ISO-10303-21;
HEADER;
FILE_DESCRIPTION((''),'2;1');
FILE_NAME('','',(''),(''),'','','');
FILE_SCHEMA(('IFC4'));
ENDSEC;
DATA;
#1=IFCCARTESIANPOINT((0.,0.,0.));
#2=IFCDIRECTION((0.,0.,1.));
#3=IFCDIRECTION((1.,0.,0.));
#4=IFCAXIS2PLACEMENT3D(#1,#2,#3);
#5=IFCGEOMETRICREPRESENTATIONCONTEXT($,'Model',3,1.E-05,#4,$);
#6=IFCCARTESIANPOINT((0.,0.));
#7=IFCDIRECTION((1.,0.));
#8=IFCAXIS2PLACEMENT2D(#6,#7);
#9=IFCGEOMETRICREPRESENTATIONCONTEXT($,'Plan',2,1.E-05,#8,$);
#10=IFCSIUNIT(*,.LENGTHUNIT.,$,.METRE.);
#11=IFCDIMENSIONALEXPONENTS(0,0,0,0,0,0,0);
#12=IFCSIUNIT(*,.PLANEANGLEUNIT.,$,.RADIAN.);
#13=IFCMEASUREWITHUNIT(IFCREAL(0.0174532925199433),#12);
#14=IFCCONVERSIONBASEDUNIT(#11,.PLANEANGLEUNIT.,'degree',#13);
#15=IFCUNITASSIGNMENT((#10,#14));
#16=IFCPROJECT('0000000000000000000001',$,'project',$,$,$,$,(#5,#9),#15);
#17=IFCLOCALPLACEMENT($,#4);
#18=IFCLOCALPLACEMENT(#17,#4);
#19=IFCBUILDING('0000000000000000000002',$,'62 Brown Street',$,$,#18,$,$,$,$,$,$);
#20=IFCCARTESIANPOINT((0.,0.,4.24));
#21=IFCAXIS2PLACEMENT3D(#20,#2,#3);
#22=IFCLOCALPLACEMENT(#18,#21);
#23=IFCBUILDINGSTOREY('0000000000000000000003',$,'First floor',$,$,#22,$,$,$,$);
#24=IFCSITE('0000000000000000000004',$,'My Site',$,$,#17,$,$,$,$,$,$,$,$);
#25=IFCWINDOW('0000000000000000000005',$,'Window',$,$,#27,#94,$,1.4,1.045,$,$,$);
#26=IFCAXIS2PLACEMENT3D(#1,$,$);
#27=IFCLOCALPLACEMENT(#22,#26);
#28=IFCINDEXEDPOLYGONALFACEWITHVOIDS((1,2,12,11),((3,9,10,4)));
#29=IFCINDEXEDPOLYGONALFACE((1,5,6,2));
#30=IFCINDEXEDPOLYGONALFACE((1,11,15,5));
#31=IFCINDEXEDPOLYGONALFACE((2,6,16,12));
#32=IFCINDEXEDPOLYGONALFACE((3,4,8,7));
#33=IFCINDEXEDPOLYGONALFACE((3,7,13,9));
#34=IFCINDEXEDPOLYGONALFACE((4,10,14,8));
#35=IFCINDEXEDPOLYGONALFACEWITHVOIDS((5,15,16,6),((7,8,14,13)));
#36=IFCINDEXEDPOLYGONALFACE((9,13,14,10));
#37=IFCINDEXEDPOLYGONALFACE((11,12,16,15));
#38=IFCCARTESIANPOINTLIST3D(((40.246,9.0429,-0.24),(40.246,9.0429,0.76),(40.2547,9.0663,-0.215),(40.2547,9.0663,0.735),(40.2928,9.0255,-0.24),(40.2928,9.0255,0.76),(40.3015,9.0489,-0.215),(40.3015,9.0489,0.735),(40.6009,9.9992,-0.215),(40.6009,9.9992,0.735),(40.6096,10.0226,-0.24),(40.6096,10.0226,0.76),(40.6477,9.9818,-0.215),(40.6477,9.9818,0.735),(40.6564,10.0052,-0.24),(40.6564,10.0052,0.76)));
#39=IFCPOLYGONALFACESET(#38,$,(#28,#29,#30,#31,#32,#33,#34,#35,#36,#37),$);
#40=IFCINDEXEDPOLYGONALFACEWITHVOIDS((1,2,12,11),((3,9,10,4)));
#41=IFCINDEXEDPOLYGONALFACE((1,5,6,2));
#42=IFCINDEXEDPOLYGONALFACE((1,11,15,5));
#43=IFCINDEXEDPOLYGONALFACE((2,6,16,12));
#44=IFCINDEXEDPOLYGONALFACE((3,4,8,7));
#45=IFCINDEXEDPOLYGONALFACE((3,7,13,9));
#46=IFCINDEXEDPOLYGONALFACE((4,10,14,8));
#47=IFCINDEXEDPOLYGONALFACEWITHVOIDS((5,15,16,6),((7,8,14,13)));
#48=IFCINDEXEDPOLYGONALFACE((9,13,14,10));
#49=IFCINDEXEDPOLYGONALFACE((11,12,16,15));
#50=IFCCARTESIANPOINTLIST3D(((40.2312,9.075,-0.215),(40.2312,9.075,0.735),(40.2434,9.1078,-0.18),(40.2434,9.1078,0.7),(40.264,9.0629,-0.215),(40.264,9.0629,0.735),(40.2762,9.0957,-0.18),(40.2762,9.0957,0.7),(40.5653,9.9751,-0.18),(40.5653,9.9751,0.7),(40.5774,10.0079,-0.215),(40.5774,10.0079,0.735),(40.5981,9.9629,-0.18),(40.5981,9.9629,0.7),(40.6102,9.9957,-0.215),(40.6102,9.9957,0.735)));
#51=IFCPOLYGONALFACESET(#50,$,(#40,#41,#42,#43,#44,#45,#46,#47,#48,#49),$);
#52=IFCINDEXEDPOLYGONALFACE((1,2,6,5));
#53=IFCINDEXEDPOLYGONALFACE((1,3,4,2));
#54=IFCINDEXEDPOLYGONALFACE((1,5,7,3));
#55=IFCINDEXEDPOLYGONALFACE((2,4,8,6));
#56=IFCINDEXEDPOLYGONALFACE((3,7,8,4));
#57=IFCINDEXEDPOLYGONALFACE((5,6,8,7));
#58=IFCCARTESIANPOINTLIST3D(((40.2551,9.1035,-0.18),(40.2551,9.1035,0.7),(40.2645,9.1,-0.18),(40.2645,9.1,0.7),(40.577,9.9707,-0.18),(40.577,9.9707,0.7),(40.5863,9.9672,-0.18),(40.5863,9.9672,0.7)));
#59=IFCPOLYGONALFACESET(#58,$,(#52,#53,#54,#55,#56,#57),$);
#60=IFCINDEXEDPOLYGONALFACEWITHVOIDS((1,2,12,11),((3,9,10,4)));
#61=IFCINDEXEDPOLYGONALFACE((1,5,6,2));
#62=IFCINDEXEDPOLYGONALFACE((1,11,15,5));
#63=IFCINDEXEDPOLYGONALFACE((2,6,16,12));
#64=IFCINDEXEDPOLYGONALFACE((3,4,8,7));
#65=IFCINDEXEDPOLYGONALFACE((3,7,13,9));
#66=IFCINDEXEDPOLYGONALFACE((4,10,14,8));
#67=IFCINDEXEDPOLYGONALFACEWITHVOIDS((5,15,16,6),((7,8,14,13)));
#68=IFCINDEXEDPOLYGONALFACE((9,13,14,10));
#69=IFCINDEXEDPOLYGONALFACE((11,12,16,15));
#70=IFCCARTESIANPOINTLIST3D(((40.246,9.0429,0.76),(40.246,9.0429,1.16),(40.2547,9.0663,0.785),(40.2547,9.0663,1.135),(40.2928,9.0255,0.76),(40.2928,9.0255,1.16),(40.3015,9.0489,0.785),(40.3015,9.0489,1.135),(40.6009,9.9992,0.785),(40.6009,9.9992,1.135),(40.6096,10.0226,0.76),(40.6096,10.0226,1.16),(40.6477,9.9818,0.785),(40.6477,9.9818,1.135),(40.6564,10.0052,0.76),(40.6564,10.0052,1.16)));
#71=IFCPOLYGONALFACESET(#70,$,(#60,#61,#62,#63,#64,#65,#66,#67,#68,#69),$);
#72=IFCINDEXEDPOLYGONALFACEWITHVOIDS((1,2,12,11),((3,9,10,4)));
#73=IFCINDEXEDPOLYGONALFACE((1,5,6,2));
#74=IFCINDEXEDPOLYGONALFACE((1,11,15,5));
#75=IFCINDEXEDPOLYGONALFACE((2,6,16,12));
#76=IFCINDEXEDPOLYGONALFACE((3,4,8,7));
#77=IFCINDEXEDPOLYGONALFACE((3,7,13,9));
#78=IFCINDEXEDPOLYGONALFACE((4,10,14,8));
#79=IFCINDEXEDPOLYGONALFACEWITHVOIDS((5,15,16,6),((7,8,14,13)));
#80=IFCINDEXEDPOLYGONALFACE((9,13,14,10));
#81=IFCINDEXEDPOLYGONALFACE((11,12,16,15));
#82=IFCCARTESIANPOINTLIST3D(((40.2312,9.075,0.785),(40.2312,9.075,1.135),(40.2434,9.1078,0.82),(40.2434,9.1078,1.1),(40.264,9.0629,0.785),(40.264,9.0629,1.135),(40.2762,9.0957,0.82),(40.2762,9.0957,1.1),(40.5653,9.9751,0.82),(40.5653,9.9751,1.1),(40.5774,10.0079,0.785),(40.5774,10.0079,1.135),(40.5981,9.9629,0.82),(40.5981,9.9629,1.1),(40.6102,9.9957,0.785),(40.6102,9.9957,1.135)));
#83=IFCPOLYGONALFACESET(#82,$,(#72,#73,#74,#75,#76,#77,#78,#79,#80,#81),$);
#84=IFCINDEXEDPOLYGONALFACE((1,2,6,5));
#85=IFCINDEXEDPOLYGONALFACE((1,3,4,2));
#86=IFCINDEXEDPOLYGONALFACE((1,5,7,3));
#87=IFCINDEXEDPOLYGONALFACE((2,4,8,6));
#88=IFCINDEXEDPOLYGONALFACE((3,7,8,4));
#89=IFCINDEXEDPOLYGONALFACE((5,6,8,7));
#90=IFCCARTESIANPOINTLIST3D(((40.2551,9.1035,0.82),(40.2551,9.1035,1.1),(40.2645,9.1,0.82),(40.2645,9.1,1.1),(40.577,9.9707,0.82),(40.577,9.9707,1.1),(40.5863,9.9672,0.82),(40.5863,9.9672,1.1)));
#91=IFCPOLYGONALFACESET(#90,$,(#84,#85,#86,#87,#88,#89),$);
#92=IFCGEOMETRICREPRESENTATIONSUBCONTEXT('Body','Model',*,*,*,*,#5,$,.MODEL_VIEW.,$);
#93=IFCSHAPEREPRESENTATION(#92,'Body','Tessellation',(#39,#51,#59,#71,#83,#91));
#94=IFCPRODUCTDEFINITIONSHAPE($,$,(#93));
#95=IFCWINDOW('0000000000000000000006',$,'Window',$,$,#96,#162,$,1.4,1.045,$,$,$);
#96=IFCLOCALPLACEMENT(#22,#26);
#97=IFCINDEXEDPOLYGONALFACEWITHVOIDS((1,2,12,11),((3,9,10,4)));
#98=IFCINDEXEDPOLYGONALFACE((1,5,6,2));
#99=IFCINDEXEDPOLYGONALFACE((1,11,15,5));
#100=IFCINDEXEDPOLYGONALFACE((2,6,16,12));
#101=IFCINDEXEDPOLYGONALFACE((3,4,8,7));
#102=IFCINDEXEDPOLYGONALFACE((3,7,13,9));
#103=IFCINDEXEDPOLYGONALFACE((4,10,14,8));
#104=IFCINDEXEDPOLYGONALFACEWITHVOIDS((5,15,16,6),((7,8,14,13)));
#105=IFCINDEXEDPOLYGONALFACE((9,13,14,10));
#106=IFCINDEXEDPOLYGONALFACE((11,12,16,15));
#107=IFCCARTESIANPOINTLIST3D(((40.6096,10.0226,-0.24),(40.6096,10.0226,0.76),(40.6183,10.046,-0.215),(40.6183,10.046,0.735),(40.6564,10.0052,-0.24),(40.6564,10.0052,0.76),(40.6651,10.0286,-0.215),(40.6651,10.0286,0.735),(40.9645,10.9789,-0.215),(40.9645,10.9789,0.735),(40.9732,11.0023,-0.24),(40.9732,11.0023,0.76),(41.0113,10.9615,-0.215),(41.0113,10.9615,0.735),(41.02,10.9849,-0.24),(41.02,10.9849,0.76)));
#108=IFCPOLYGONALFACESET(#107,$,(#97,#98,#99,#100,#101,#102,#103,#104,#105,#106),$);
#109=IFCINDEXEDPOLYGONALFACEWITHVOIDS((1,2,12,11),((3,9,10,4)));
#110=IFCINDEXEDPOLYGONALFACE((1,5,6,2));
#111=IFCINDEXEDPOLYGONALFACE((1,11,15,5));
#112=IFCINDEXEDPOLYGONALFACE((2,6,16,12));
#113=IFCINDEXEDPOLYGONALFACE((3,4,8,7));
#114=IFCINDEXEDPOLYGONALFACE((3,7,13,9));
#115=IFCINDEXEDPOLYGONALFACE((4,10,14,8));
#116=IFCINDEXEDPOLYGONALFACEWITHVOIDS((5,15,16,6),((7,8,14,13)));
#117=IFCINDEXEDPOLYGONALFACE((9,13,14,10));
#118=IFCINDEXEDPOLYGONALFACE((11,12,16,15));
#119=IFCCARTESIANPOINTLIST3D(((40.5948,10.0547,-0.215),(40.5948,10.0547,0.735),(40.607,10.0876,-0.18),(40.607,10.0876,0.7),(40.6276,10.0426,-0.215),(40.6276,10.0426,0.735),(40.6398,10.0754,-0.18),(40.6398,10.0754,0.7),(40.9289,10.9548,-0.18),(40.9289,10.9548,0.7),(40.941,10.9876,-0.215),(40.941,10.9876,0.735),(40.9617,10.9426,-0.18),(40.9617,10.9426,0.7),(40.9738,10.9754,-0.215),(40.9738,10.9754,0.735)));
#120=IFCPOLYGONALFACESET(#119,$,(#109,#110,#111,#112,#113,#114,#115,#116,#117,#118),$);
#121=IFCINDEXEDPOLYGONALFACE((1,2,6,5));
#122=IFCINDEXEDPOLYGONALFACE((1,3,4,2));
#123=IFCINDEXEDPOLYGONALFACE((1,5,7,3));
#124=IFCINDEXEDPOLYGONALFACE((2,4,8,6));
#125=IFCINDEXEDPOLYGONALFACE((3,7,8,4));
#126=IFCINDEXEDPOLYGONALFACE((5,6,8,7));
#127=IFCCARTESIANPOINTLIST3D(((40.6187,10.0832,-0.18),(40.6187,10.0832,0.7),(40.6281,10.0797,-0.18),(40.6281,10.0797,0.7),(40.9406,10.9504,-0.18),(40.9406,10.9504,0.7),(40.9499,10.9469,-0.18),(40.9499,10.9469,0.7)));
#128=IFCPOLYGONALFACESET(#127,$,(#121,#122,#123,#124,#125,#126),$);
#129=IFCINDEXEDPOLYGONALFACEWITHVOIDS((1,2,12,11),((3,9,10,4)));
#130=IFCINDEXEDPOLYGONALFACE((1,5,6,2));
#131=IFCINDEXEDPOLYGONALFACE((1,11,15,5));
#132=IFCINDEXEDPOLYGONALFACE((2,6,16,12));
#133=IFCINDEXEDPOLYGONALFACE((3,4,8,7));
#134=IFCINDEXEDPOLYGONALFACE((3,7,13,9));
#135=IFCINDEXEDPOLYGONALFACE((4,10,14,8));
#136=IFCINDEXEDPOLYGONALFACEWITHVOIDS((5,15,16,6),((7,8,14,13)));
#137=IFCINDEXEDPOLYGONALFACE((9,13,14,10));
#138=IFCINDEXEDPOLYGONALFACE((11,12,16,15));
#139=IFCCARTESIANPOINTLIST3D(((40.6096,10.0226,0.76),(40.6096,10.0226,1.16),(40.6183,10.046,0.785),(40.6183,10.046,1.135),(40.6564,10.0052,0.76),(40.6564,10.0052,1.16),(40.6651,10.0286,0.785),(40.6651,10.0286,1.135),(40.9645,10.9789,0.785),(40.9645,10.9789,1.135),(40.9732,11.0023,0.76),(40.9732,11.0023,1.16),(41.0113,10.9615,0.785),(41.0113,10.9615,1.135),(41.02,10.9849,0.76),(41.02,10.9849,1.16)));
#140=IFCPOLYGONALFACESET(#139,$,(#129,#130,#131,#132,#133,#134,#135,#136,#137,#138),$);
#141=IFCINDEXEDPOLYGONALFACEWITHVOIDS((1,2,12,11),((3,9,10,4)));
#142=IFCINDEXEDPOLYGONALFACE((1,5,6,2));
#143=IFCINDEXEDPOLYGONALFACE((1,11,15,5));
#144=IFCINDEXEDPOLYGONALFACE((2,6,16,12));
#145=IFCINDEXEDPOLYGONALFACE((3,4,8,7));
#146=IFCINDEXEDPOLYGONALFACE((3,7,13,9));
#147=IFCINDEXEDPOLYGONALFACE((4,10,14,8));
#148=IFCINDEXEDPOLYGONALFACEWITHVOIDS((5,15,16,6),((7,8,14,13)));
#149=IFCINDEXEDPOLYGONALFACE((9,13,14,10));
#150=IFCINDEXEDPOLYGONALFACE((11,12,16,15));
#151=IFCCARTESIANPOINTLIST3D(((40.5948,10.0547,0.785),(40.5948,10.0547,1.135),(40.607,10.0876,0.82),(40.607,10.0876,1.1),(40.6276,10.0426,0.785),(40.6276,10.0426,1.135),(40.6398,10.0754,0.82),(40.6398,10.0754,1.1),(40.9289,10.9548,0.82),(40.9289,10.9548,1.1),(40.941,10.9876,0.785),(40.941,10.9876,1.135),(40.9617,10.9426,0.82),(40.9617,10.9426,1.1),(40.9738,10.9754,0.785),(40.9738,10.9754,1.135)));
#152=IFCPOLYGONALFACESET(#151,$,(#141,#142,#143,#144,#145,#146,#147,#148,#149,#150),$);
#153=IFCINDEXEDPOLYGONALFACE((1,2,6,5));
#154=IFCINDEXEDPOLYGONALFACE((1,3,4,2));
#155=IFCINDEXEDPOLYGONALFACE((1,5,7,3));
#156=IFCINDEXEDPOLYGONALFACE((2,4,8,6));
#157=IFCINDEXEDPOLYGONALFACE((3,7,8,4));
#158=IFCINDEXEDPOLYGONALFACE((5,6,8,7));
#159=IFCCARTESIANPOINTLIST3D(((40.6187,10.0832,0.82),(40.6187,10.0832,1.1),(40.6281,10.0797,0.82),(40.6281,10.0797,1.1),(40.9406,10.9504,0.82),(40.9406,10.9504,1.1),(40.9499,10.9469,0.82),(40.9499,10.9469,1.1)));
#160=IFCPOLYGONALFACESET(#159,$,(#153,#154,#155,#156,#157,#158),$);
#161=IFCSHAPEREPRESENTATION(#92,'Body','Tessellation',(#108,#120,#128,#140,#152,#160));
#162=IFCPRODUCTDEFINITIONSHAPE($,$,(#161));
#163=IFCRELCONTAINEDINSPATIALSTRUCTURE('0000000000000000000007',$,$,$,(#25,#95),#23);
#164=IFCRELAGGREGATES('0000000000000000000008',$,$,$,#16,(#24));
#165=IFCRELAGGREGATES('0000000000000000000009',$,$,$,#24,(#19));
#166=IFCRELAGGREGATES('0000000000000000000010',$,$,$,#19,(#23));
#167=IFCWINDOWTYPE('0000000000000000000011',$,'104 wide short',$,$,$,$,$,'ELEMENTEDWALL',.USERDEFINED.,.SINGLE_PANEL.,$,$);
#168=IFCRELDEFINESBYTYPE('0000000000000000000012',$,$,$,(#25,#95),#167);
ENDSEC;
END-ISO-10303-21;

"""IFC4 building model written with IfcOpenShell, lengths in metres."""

from ifc_helpers import new_model, entity, si_unit, converted_unit, frame, origin_with_axes, origin_2d_with_axis, place, context, subcontext, project, spatial, line, indexed_curve, outline, extrude, shape, source, transform, mapped, type_object, type_shapes, element, save


model = new_model("IFC4")

# Units and contexts
model_context = context("Model", 3, precision=1e-05, world=origin_with_axes())
plan_context = context("Plan", 2, precision=1e-05, world=origin_2d_with_axis())
body_context_1 = subcontext(model_context, "Body", "Model", "MODEL_VIEW")
body_context_2 = subcontext(plan_context, "Body", "Plan", "PLAN_VIEW")
ifc_project = project(units=[si_unit("LENGTHUNIT", "METRE"), converted_unit("PLANEANGLEUNIT", "degree", entity("IfcReal", 0.0174532925199433), si_unit("PLANEANGLEUNIT", "RADIAN"), dimensions=[0, 0, 0, 0, 0, 0, 0])], contexts=[model_context, plan_context])

# Site, building, storey
site_placement = place(None, origin_with_axes())
site = spatial("IfcSite", under=ifc_project, at=site_placement, Name="My Site")
building_placement = place(site_placement, origin_with_axes())
building = spatial("IfcBuilding", under=site, at=building_placement, Name="62 Brown Street")
storey_placement = place(building_placement, frame((0.0, 0.0, 4.24), z_axis=(0.0, 0.0, 1.0), x_axis=(1.0, 0.0, 0.0)))
storey = spatial("IfcBuildingStorey", under=building, at=storey_placement, Name="First floor")

# Shared definitions
window_type = type_object("IfcWindowType", Name="104 wide short", ElementType="ELEMENTEDWALL", PartitioningType="SINGLE_PANEL", PredefinedType="USERDEFINED")
shared_shape_1 = source(origin_with_axes(), body_context_1, "Body", "SweptSolid", [
    extrude(outline(indexed_curve([(0.0, 0.0), (1.045, 0.0), (1.045, 1.0), (0.0, 1.0)], segments=[line(1, 2, 3, 4, 1)]), holes=[indexed_curve([(0.025, 0.025), (1.02, 0.025), (1.02, 0.975), (0.025, 0.975)], segments=[line(1, 2, 3, 4, 1)])]), frame((0.0, 0.15, 0.0), z_axis=(0.0, -1.0, 0.0), x_axis=(1.0, 0.0, 0.0)), (0.0, 0.0, -1.0), 0.05),
    extrude(outline(indexed_curve([(0.0, 0.0), (0.995, 0.0), (0.995, 0.95), (0.0, 0.95)], segments=[line(1, 2, 3, 4, 1)]), holes=[indexed_curve([(0.035, 0.035), (0.96, 0.035), (0.96, 0.915), (0.035, 0.915)], segments=[line(1, 2, 3, 4, 1)])]), frame((0.025, 0.19, 0.025), z_axis=(0.0, -1.0, 0.0), x_axis=(1.0, 0.0, 0.0)), (0.0, 0.0, -1.0), 0.035),
    extrude(outline(indexed_curve([(0.035, 0.035), (0.96, 0.035), (0.96, 0.915), (0.035, 0.915)], segments=[line(1, 2, 3, 4, 1)])), frame((0.025, 0.2025, 0.025), z_axis=(0.0, -1.0, 0.0), x_axis=(1.0, 0.0, 0.0)), (0.0, 0.0, -1.0), 0.01),
    extrude(outline(indexed_curve([(0.0, 0.0), (1.045, 0.0), (1.045, 0.4), (0.0, 0.4)], segments=[line(1, 2, 3, 4, 1)]), holes=[indexed_curve([(0.025, 0.025), (1.02, 0.025), (1.02, 0.375), (0.025, 0.375)], segments=[line(1, 2, 3, 4, 1)])]), frame((0.0, 0.15, 1.0), z_axis=(0.0, -1.0, 0.0), x_axis=(1.0, 0.0, 0.0)), (0.0, 0.0, -1.0), 0.05),
    extrude(outline(indexed_curve([(0.0, 0.0), (0.995, 0.0), (0.995, 0.35), (0.0, 0.35)], segments=[line(1, 2, 3, 4, 1)]), holes=[indexed_curve([(0.035, 0.035), (0.96, 0.035), (0.96, 0.315), (0.035, 0.315)], segments=[line(1, 2, 3, 4, 1)])]), frame((0.025, 0.19, 1.025), z_axis=(0.0, -1.0, 0.0), x_axis=(1.0, 0.0, 0.0)), (0.0, 0.0, -1.0), 0.035),
    extrude(outline(indexed_curve([(0.035, 0.035), (0.96, 0.035), (0.96, 0.315), (0.035, 0.315)], segments=[line(1, 2, 3, 4, 1)])), frame((0.025, 0.2025, 1.025), z_axis=(0.0, -1.0, 0.0), x_axis=(1.0, 0.0, 0.0)), (0.0, 0.0, -1.0), 0.01),
])
shared_shape_2 = source(origin_with_axes(), body_context_2, "Body", "Curve2D", [
    entity("IfcIndexedPolyCurve", entity("IfcCartesianPointList2D", [[0.025, 0.15], [1.02, 0.15]])),
    entity("IfcIndexedPolyCurve", entity("IfcCartesianPointList2D", [[0.0, 0.2], [0.025, 0.2], [0.025, 0.15], [0.0, 0.15]]), [entity("IfcLineIndex", [1, 2, 3, 4, 1])]),
    entity("IfcIndexedPolyCurve", entity("IfcCartesianPointList2D", [[1.045, 0.2], [1.02, 0.2], [1.02, 0.15], [1.045, 0.15]]), [entity("IfcLineIndex", [1, 2, 3, 4, 1])]),
    entity("IfcIndexedPolyCurve", entity("IfcCartesianPointList2D", [[0.025, 0.19], [0.06, 0.19], [0.06, 0.225], [0.025, 0.225]]), [entity("IfcLineIndex", [1, 2, 3, 4, 1])]),
    entity("IfcIndexedPolyCurve", entity("IfcCartesianPointList2D", [[1.02, 0.19], [0.985, 0.19], [0.985, 0.225], [1.02, 0.225]]), [entity("IfcLineIndex", [1, 2, 3, 4, 1])]),
    entity("IfcIndexedPolyCurve", entity("IfcCartesianPointList2D", [[0.06, 0.19], [0.985, 0.19]])),
    entity("IfcIndexedPolyCurve", entity("IfcCartesianPointList2D", [[0.06, 0.225], [0.985, 0.225]])),
    entity("IfcIndexedPolyCurve", entity("IfcCartesianPointList2D", [[0.06, 0.2075], [0.985, 0.2075]])),
])
type_shapes(window_type, [shared_shape_1, shared_shape_2])

# Windows
for number, where, z_axis, x_axis, name in (
    (1, (40.4335, 8.9733, -0.24), (0.0, 0.0, 1.0), (0.347944, 0.937515, 0.0), "Window"),
    (2, (40.7971, 9.953, -0.24), (0.0, 0.0, 1.0), (0.347944, 0.937515, 0.0), "Window"),
):
    element("IfcWindow", number, at=place(storey_placement, frame(where, z_axis=z_axis, x_axis=x_axis)), inside=storey, type_object=window_type, Name=name, OverallHeight=1.4, OverallWidth=1.045, shapes=[
        shape(body_context_1, "Body", "MappedRepresentation", [mapped(shared_shape_1, transform((0.0, 0.0, 0.0), x_axis=(1.0, 0.0, 0.0), y_axis=(0.0, 1.0, 0.0), z_axis=(0.0, 0.0, 1.0), scale=1.0))]),
        shape(body_context_2, "Body", "MappedRepresentation", [mapped(shared_shape_2, transform((0.0, 0.0, 0.0), x_axis=(1.0, 0.0, 0.0), y_axis=(0.0, 1.0, 0.0), z_axis=(0.0, 0.0, 1.0), scale=1.0))]),
    ])

save(model, "model.ifc")
